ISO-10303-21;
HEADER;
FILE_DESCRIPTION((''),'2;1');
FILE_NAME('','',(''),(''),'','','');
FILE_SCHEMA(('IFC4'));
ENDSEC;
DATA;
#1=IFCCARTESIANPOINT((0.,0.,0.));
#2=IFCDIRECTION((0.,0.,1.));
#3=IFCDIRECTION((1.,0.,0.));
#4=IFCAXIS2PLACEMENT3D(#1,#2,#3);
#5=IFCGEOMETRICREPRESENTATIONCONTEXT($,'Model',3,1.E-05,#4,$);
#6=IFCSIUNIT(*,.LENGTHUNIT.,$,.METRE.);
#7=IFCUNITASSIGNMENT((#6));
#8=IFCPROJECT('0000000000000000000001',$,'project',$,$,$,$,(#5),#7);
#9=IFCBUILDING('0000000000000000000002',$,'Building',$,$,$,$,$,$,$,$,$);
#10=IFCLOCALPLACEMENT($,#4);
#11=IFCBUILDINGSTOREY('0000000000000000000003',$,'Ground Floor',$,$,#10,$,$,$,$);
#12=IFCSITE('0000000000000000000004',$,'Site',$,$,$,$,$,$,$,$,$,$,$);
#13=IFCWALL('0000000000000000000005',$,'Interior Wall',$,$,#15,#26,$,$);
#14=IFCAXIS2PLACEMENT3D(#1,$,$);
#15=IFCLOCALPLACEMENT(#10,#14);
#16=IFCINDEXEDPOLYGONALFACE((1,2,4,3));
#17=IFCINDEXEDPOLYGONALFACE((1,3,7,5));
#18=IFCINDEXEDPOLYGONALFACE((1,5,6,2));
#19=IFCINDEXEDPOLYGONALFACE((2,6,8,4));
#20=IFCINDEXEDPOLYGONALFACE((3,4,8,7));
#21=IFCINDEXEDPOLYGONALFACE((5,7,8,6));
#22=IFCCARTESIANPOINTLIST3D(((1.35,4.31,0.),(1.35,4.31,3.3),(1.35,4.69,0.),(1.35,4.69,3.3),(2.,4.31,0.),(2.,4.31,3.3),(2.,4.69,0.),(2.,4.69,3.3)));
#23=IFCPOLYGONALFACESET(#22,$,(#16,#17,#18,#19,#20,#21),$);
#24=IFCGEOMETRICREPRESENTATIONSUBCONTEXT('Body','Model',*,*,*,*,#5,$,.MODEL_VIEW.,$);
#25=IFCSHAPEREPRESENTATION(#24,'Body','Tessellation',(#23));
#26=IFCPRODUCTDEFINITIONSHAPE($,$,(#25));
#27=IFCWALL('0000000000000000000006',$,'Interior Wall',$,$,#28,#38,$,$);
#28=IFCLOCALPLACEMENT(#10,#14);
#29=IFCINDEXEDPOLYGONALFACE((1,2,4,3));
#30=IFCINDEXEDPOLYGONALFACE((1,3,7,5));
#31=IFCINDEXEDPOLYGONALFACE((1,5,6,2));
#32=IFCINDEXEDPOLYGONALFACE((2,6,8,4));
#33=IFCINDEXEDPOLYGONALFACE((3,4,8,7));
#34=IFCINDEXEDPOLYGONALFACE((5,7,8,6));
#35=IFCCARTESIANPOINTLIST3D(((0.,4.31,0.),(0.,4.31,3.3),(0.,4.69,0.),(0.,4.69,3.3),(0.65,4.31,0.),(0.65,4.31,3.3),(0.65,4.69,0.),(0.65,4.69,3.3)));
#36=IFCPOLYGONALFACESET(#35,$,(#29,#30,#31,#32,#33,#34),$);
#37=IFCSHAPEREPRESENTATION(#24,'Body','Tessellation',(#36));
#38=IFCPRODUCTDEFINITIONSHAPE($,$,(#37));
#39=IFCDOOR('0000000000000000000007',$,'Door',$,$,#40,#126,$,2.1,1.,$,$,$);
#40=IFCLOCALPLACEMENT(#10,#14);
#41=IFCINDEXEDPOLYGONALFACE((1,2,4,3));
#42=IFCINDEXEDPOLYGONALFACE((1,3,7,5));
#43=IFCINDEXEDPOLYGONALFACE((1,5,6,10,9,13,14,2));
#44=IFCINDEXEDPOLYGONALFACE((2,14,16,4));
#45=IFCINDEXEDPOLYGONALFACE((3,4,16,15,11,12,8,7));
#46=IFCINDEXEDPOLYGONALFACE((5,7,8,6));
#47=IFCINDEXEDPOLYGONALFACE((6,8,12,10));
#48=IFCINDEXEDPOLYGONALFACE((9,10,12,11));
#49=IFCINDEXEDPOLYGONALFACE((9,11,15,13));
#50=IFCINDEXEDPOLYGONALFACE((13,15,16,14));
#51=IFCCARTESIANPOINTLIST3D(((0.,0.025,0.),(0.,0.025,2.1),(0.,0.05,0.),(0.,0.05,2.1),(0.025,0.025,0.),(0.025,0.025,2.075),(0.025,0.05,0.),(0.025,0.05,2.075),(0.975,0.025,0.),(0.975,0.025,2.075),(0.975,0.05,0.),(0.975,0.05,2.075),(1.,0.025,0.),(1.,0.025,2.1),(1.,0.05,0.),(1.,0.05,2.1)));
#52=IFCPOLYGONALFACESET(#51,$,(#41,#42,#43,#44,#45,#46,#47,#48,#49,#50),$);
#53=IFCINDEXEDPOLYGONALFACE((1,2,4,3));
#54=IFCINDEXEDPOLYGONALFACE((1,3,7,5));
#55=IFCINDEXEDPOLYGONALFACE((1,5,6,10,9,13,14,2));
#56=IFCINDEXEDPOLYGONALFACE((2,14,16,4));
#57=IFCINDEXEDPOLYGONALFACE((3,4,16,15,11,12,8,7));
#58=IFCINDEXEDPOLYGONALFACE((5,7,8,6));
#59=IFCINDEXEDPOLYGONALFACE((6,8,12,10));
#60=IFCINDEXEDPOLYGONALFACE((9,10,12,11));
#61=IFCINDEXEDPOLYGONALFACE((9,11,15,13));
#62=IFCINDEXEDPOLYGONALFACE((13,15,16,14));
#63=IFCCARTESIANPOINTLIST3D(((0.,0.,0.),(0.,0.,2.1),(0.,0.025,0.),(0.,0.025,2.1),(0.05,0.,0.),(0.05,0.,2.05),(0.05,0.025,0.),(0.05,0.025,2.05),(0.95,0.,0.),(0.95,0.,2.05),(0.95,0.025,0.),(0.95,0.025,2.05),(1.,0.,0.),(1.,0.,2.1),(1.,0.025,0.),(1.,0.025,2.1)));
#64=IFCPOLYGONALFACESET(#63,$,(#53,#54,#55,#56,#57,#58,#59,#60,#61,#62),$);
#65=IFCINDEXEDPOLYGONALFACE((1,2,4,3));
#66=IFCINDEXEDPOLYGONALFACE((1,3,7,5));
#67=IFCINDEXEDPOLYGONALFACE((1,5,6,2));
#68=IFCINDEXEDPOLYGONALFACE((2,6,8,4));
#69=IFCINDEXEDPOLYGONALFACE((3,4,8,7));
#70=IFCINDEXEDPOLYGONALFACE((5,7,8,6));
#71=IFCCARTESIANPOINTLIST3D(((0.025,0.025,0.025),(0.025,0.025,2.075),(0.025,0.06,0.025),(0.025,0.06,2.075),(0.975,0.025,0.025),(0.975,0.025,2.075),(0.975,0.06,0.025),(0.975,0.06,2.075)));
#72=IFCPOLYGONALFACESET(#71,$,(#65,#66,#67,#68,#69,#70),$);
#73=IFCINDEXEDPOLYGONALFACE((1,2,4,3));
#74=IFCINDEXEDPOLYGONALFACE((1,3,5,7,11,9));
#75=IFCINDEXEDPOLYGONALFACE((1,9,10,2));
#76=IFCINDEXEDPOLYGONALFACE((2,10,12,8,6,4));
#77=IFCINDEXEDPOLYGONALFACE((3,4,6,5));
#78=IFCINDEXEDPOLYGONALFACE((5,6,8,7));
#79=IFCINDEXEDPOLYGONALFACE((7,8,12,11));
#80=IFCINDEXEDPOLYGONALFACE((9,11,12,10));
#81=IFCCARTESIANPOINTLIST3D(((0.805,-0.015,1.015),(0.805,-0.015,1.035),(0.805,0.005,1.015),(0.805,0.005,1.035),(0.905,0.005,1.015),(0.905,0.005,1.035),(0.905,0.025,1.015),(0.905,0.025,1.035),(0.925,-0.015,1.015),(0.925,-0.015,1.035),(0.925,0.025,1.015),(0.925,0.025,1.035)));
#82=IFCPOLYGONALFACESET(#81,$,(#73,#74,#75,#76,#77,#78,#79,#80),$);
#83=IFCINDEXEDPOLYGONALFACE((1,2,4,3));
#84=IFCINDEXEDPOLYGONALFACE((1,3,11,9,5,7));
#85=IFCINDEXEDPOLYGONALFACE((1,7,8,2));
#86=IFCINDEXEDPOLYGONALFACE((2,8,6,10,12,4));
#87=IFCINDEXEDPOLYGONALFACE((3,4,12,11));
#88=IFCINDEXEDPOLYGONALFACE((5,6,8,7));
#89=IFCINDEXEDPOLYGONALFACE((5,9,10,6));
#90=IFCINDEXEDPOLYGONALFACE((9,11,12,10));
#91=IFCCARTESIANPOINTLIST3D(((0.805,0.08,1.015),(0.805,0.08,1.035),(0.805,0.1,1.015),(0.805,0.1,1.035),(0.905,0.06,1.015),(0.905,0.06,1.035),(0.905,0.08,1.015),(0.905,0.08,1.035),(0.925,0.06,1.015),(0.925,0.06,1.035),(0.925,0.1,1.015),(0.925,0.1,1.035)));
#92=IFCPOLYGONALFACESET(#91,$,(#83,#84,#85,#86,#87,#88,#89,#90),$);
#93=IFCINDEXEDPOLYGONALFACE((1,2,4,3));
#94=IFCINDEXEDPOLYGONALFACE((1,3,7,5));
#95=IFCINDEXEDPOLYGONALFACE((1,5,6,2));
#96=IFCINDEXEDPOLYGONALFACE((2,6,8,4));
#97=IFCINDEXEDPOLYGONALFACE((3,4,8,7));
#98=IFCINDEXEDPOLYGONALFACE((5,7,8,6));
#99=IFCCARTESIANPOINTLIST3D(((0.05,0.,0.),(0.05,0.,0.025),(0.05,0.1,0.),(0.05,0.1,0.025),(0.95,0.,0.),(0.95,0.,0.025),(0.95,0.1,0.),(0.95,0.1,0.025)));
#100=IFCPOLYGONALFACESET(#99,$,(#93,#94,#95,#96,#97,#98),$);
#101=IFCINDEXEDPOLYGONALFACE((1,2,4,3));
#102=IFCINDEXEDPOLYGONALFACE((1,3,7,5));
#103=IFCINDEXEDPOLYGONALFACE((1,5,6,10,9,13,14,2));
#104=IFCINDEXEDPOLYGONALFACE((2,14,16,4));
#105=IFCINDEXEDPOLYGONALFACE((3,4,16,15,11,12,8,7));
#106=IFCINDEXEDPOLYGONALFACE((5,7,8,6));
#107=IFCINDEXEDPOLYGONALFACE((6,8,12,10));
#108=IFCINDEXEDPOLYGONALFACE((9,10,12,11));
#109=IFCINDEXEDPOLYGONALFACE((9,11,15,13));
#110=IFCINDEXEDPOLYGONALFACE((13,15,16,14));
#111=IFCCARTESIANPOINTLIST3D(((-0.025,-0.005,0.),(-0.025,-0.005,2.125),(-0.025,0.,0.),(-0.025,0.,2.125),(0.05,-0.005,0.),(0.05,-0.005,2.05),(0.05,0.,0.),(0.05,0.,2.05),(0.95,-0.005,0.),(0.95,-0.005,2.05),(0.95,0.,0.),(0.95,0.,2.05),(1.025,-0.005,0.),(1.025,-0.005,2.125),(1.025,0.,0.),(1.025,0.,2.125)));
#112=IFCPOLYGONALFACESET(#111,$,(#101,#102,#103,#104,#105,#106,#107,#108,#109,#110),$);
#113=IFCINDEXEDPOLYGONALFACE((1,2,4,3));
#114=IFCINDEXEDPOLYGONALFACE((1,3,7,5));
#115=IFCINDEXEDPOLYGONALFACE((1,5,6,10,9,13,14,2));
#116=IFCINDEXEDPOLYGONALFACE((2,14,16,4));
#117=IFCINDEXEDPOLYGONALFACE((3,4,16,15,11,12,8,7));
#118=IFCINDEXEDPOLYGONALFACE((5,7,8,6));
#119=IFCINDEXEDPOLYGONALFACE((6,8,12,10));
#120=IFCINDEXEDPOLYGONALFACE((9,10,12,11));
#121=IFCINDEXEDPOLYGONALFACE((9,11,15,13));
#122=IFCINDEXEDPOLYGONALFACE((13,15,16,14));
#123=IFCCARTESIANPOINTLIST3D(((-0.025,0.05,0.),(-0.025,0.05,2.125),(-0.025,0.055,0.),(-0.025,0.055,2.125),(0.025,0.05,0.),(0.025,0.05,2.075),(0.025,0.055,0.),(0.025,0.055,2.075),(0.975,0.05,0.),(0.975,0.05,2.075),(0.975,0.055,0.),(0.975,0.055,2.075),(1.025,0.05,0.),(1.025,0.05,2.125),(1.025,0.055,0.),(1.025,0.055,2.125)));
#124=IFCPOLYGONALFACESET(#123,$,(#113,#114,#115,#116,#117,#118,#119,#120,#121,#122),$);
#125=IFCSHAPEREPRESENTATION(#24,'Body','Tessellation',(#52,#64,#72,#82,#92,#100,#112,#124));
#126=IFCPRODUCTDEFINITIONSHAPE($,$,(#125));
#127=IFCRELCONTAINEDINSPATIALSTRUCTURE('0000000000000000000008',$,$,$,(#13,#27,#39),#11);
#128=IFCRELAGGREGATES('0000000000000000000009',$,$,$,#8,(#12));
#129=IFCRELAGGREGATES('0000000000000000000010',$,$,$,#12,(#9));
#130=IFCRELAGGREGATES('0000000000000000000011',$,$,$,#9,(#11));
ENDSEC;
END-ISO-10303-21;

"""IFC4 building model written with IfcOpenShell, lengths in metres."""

from ifc_helpers import new_model, si_unit, frame, origin_with_axes, place, context, subcontext, project, spatial, line, indexed_curve, outline, extrude, element, save


model = new_model("IFC4")

# Units and contexts
model_context = context("Model", 3, precision=1e-05, world=origin_with_axes())
body_context = subcontext(model_context, "Body", "Model", "MODEL_VIEW")
ifc_project = project(units=[si_unit("LENGTHUNIT", "METRE")], contexts=[model_context])

# Site, building, storey
site = spatial("IfcSite", under=ifc_project, Name="Site")
building = spatial("IfcBuilding", under=site, Name="Building")
storey_placement = place(None, origin_with_axes())
storey = spatial("IfcBuildingStorey", under=building, at=storey_placement, Name="Ground Floor")

# Walls
for number, where, z_axis, x_axis, name in (
    (1, (2.0, 4.5, 0.0), (0.0, 0.0, 1.0), (-1.0, 0.0, 0.0), "Interior Wall"),
    (2, (0.65, 4.5, 0.0), (0.0, 0.0, 1.0), (-1.0, 0.0, 0.0), "Interior Wall"),
):
    element("IfcWall", number, at=place(storey_placement, frame(where, z_axis=z_axis, x_axis=x_axis)), inside=storey, Name=name, context=body_context, shape_type="SweptSolid", body=[
        extrude(outline(indexed_curve([(0.0, 0.0), (0.0, 0.38), (0.65, 0.38), (0.65, 0.0), (0.0, 0.0)], self_intersect=False)), frame((0.0, -0.19, 0.0), z_axis=(0.0, 0.0, 1.0), x_axis=(1.0, 0.0, 0.0)), (0.0, 0.0, 1.0), 3.3),
    ])

# Door
door_1_placement = place(storey_placement, origin_with_axes())
element("IfcDoor", 3, at=door_1_placement, inside=storey, Name="Door", OverallHeight=2.1, OverallWidth=1.0, context=body_context, shape_type="SweptSolid", body=[
    extrude(outline(indexed_curve([(0.0, 0.0), (0.0, 2.1), (1.0, 2.1), (1.0, 0.0), (0.975, 0.0), (0.975, 2.075), (0.025, 2.075), (0.025, 0.0)], segments=[line(1, 2, 3, 4, 5, 6, 7, 8, 1)])), frame((0.0, 0.025, 0.0), z_axis=(0.0, -1.0, 0.0), x_axis=(1.0, 0.0, 0.0)), (0.0, 0.0, -1.0), 0.025),
    extrude(outline(indexed_curve([(0.0, 0.0), (0.0, 2.1), (1.0, 2.1), (1.0, 0.0), (0.95, 0.0), (0.95, 2.05), (0.05, 2.05), (0.05, 0.0)], segments=[line(1, 2, 3, 4, 5, 6, 7, 8, 1)])), frame((0.0, 0.0, 0.0), z_axis=(0.0, -1.0, 0.0), x_axis=(1.0, 0.0, 0.0)), (0.0, 0.0, -1.0), 0.025),
    extrude(outline(indexed_curve([(0.0, 0.0), (0.95, 0.0), (0.95, 0.035), (0.0, 0.035)], segments=[line(1, 2, 3, 4, 1)])), frame((0.025, 0.025, 0.025), z_axis=(0.0, 0.0, 1.0), x_axis=(1.0, 0.0, 0.0)), (0.0, 0.0, 1.0), 2.05),
    extrude(outline(indexed_curve([(0.0, 0.0), (0.0, -0.04), (-0.12, -0.04), (-0.12, -0.02), (-0.02, -0.02), (-0.02, 0.0)], segments=[line(1, 2, 3, 4, 5, 6, 1)])), frame((0.925, 0.025, 1.015), z_axis=(0.0, 0.0, 1.0), x_axis=(1.0, 0.0, 0.0)), (0.0, 0.0, 1.0), 0.02),
    extrude(outline(indexed_curve([(0.0, 0.0), (0.0, 0.04), (-0.12, 0.04), (-0.12, 0.02), (-0.02, 0.02), (-0.02, 0.0)], segments=[line(1, 2, 3, 4, 5, 6, 1)])), frame((0.925, 0.06, 1.015), z_axis=(0.0, 0.0, 1.0), x_axis=(1.0, 0.0, 0.0)), (0.0, 0.0, 1.0), 0.02),
    extrude(outline(indexed_curve([(0.0, 0.0), (0.9, 0.0), (0.9, 0.1), (0.0, 0.1)], segments=[line(1, 2, 3, 4, 1)])), frame((0.05, 0.0, 0.0), z_axis=(0.0, 0.0, 1.0), x_axis=(1.0, 0.0, 0.0)), (0.0, 0.0, 1.0), 0.025),
    extrude(outline(indexed_curve([(0.0, 0.0), (0.0, 2.125), (1.05, 2.125), (1.05, 0.0), (0.975, 0.0), (0.975, 2.05), (0.075, 2.05), (0.075, 0.0)], segments=[line(1, 2, 3, 4, 5, 6, 7, 8, 1)])), frame((-0.025, -0.005, 0.0), z_axis=(0.0, -1.0, 0.0), x_axis=(1.0, 0.0, 0.0)), (0.0, 0.0, -1.0), 0.005),
    extrude(outline(indexed_curve([(0.0, 0.0), (0.0, 2.125), (1.05, 2.125), (1.05, 0.0), (1.0, 0.0), (1.0, 2.075), (0.05, 2.075), (0.05, 0.0)], segments=[line(1, 2, 3, 4, 5, 6, 7, 8, 1)])), frame((-0.025, 0.05, 0.0), z_axis=(0.0, -1.0, 0.0), x_axis=(1.0, 0.0, 0.0)), (0.0, 0.0, -1.0), 0.005),
])

save(model, "model.ifc")
